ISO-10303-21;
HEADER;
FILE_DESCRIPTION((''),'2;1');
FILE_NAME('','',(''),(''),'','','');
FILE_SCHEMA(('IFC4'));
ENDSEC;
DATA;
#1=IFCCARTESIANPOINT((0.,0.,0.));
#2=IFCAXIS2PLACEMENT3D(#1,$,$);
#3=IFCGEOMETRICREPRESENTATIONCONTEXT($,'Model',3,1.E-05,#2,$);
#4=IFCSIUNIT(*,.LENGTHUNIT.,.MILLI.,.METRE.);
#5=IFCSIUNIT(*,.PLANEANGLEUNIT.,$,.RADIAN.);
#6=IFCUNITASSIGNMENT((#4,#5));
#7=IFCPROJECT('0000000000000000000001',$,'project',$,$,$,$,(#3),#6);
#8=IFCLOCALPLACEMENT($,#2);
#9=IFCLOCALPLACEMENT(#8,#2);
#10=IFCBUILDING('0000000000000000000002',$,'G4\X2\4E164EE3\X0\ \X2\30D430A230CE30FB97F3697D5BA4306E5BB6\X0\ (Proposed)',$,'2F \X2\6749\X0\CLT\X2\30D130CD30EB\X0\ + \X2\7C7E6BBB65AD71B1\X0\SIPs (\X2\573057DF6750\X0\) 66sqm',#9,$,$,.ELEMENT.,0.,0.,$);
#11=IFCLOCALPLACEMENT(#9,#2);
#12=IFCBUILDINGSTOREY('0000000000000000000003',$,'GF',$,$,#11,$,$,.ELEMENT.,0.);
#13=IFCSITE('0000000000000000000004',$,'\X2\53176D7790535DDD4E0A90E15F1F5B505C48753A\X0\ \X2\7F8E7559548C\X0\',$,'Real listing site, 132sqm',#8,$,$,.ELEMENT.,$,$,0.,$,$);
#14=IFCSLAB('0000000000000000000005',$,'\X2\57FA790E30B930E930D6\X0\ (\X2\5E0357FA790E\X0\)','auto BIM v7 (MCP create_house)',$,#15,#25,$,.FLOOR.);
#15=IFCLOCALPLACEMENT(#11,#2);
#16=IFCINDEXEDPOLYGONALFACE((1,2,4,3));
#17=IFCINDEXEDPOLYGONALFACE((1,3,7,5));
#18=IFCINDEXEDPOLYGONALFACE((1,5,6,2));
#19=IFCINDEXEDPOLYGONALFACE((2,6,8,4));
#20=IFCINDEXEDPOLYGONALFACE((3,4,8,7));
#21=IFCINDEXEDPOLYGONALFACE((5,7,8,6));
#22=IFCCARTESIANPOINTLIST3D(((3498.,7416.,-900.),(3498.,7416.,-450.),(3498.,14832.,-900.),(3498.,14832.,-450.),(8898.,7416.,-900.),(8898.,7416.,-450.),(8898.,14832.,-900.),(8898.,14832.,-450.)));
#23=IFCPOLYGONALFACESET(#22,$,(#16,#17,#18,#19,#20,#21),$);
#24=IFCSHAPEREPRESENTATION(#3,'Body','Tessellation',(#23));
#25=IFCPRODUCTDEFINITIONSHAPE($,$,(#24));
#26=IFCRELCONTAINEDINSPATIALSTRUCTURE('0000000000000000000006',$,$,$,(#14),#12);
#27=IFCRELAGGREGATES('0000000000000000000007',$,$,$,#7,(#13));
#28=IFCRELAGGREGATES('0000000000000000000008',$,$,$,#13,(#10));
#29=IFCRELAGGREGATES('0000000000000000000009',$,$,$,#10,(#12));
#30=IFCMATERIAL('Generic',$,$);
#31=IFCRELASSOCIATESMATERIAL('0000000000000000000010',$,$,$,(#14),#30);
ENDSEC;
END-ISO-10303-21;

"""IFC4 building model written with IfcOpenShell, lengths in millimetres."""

from ifc_helpers import new_model, si_unit, frame, frame_2d, origin, place, context, project, spatial, rectangle, extrude, material, element, save


model = new_model("IFC4")

# Units and contexts
model_context = context("Model", 3, precision=1e-05, world=origin())
ifc_project = project(units=[si_unit("LENGTHUNIT", "METRE", prefix="MILLI"), si_unit("PLANEANGLEUNIT", "RADIAN")], contexts=[model_context])

# Site, building, storey
site_placement = place(None, origin())
site = spatial("IfcSite", under=ifc_project, at=site_placement, Name="北海道川上郡弟子屈町 美留和", ObjectType="Real listing site, 132sqm", CompositionType="ELEMENT", RefElevation=0.0)
building_placement = place(site_placement, origin())
building = spatial("IfcBuilding", under=site, at=building_placement, Name="G4世代 ピアノ・音楽室の家 (Proposed)", ObjectType="2F 杉CLTパネル + 籾殻断熱SIPs (地域材) 66sqm", CompositionType="ELEMENT", ElevationOfRefHeight=0.0, ElevationOfTerrain=0.0)
storey_placement = place(building_placement, origin())
storey = spatial("IfcBuildingStorey", under=building, at=storey_placement, Name="GF", CompositionType="ELEMENT", Elevation=0.0)

# Slab
ifc_material = material(Name="Generic")
slab_1_placement = place(storey_placement, frame((1749.0, 3708.0, -450.0)))
element("IfcSlab", 1, at=slab_1_placement, inside=storey, material=ifc_material, Name="基礎スラブ (布基礎)", Description="auto BIM v7 (MCP create_house)", PredefinedType="FLOOR", context=model_context, shape_type="SweptSolid", body=[
    extrude(rectangle(XDim=5400.0, YDim=7416.0, at=frame_2d((2700.0, 3708.0))), frame((1749.0, 3708.0, -450.0)), (0.0, 0.0, 1.0), 450.0),
])

save(model, "model.ifc")
